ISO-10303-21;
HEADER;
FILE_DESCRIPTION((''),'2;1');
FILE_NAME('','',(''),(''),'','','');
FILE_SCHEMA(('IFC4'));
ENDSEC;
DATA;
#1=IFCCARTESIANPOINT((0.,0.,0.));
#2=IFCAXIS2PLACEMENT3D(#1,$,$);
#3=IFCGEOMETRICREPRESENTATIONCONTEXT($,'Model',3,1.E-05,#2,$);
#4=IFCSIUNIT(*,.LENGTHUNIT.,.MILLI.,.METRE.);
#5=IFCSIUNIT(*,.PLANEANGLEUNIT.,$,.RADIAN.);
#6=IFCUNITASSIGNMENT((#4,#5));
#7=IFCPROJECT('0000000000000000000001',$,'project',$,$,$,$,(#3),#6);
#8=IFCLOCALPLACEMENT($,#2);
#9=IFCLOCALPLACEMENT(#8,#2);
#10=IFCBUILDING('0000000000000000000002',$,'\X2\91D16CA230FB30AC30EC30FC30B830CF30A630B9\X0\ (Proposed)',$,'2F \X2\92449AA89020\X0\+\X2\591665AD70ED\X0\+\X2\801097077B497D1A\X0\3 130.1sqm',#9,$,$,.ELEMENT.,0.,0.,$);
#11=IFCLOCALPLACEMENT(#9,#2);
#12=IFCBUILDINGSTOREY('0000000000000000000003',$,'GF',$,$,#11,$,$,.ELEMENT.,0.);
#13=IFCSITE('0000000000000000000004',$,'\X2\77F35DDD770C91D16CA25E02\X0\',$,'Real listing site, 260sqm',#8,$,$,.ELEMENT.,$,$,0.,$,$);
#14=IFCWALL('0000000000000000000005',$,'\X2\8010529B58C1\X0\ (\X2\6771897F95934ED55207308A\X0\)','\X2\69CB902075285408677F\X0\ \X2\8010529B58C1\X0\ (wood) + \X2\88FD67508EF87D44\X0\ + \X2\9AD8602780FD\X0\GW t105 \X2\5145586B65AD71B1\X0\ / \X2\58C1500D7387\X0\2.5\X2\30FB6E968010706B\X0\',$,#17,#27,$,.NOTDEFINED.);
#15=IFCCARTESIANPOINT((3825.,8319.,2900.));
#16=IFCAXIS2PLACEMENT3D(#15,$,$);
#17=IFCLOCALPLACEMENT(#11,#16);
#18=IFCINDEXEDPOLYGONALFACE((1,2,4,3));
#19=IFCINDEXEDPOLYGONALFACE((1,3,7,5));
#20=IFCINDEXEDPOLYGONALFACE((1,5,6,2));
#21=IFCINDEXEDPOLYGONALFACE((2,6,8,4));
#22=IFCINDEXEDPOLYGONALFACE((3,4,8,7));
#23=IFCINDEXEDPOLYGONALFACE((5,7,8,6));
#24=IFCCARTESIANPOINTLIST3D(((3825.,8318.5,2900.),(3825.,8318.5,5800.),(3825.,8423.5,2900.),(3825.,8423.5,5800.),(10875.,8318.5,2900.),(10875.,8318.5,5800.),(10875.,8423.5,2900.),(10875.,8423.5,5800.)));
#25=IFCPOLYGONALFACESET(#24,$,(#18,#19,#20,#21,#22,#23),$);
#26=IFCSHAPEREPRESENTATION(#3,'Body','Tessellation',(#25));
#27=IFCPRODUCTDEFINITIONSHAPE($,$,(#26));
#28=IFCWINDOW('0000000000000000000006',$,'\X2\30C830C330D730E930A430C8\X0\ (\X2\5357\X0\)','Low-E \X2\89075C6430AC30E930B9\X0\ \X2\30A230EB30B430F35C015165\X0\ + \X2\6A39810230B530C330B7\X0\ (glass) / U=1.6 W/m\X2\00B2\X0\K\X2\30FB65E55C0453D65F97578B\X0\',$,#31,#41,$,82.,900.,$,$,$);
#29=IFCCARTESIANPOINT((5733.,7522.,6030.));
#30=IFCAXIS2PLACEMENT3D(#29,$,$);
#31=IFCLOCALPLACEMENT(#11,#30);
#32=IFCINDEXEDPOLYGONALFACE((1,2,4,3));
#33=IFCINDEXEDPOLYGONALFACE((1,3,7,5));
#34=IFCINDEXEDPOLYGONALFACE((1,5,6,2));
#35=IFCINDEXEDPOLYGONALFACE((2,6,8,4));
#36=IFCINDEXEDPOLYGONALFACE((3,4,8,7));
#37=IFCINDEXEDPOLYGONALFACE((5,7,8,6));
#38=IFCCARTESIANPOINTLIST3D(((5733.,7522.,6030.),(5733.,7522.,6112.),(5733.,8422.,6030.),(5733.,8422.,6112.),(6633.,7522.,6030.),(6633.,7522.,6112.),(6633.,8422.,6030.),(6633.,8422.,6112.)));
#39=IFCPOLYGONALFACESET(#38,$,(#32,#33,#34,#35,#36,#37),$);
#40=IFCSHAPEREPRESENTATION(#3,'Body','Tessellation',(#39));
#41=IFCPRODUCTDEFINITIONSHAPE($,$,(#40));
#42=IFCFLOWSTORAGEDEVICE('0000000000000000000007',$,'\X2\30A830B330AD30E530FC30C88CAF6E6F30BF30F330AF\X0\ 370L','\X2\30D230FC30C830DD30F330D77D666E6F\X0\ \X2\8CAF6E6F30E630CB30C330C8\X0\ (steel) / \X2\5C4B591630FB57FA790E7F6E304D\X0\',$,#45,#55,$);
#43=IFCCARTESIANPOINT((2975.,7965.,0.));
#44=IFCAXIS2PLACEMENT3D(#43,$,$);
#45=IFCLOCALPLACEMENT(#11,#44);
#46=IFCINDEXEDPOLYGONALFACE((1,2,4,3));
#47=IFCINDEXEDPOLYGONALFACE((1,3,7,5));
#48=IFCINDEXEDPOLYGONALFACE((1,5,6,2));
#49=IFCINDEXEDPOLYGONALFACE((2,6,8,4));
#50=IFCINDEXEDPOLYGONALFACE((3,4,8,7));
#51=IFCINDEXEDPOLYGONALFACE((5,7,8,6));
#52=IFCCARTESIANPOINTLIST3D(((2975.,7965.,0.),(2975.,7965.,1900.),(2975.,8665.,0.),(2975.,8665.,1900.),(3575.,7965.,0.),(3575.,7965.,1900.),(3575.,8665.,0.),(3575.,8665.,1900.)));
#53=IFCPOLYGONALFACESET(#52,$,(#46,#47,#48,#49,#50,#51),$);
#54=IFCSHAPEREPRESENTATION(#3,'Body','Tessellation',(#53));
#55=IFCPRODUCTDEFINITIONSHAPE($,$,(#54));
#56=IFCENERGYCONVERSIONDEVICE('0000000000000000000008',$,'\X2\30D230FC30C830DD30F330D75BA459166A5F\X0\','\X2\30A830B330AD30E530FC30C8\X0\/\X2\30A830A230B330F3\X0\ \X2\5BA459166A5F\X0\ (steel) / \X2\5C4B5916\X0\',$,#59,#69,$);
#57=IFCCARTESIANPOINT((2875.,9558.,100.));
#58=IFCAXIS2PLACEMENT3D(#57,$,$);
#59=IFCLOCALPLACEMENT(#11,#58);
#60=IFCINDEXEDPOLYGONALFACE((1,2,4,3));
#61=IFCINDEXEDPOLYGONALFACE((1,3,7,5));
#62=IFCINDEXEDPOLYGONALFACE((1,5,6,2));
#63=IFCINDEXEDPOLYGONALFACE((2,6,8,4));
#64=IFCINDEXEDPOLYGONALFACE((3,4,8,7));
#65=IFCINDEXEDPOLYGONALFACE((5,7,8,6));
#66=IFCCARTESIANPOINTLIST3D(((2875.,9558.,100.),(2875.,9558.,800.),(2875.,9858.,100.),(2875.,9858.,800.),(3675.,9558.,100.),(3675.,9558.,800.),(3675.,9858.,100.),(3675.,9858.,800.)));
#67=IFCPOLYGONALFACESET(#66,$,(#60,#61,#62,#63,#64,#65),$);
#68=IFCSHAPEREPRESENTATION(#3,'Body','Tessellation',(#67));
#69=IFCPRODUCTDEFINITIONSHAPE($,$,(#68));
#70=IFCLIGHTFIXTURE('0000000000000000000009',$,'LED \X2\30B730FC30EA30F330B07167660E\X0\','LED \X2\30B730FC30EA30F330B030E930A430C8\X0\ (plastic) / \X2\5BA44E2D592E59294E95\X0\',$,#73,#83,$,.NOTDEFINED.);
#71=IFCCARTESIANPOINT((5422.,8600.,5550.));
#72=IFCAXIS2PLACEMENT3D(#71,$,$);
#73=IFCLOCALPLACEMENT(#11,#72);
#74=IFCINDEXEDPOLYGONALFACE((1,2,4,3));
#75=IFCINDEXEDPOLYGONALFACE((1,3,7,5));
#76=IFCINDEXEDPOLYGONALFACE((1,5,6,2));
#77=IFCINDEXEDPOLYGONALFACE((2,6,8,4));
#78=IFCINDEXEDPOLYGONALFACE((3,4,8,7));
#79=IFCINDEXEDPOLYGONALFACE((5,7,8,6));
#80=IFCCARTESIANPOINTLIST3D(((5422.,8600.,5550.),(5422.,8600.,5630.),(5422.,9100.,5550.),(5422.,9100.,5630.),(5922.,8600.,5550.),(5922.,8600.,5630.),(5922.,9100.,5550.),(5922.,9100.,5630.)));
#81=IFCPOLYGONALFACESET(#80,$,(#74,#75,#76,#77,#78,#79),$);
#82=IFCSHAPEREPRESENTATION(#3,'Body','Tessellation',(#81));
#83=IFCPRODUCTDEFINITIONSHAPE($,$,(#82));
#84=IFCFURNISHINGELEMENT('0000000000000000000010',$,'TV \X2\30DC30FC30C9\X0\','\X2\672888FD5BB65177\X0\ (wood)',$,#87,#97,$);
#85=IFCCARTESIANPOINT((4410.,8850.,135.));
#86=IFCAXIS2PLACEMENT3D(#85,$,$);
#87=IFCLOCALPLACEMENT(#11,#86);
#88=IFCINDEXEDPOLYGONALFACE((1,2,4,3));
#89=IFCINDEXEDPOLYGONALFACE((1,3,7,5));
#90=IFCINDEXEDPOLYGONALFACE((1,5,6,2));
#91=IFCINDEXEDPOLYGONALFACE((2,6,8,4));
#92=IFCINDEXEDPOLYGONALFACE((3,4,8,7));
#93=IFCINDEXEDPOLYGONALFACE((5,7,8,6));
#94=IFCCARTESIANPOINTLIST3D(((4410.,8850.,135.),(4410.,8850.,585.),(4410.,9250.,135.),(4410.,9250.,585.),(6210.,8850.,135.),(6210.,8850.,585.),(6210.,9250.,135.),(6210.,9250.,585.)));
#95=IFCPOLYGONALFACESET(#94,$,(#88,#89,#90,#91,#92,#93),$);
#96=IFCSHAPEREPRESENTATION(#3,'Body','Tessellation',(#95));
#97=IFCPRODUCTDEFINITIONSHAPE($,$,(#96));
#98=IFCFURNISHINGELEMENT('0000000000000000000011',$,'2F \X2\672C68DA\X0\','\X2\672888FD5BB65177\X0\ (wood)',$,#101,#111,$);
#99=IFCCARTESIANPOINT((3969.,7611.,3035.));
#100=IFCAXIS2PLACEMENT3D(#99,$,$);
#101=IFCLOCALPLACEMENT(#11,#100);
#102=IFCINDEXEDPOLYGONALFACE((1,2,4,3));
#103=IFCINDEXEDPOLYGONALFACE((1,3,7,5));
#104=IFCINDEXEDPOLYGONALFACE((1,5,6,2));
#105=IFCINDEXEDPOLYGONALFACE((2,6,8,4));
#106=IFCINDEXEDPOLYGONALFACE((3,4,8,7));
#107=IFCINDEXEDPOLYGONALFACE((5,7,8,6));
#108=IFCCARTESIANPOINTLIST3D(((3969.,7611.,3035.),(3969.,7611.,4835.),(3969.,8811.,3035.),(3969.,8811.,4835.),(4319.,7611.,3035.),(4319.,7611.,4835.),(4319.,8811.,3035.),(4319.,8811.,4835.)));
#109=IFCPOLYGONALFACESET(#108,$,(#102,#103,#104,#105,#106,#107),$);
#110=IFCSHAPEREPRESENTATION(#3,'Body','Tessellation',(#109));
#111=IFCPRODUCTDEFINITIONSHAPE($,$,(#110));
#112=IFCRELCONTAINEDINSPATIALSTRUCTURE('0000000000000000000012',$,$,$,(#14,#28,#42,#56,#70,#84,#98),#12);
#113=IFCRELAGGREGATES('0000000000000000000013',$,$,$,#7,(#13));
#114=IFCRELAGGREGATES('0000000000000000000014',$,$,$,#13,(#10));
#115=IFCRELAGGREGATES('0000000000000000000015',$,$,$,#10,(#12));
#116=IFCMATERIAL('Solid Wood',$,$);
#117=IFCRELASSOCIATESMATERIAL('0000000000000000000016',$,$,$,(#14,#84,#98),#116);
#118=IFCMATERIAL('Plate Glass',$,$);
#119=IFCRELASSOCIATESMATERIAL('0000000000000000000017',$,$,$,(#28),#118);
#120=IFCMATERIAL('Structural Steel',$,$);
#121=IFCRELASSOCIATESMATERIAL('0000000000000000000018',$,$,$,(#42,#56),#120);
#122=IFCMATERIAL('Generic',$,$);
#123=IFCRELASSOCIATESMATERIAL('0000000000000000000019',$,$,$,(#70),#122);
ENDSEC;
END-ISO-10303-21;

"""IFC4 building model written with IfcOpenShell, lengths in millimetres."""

from ifc_helpers import new_model, si_unit, frame, frame_2d, origin, place, context, project, spatial, rectangle, extrude, material, element, save


model = new_model("IFC4")

# Units and contexts
model_context = context("Model", 3, precision=1e-05, world=origin())
ifc_project = project(units=[si_unit("LENGTHUNIT", "METRE", prefix="MILLI"), si_unit("PLANEANGLEUNIT", "RADIAN")], contexts=[model_context])

# Site, building, storey
site_placement = place(None, origin())
site = spatial("IfcSite", under=ifc_project, at=site_placement, Name="石川県金沢市", ObjectType="Real listing site, 260sqm", CompositionType="ELEMENT", RefElevation=0.0)
building_placement = place(site_placement, origin())
building = spatial("IfcBuilding", under=site, at=building_placement, Name="金沢・ガレージハウス (Proposed)", ObjectType="2F 鉄骨造+外断热+耐震等級3 130.1sqm", CompositionType="ELEMENT", ElevationOfRefHeight=0.0, ElevationOfTerrain=0.0)
storey_placement = place(building_placement, origin())
storey = spatial("IfcBuildingStorey", under=building, at=storey_placement, Name="GF", CompositionType="ELEMENT", Elevation=0.0)

# Shared definitions
ifc_material_1 = material(Name="Solid Wood")

# Wall
wall_1_placement = place(storey_placement, frame((3825.0, 8319.0, 2900.0)))
element("IfcWall", 1, at=wall_1_placement, inside=storey, material=ifc_material_1, Name="耐力壁 (東西間仕切り)", Description="構造用合板 耐力壁 (wood) + 製材軸組 + 高性能GW t105 充填断熱 / 壁倍率2.5・準耐火", PredefinedType="NOTDEFINED", context=model_context, shape_type="SweptSolid", body=[
    extrude(rectangle(XDim=7050.0, YDim=105.0, at=frame_2d((3525.0, 52.0))), frame((3825.0, 8319.0, 2900.0)), (0.0, 0.0, 1.0), 2900.0),
])

# Window
ifc_material_2 = material(Name="Plate Glass")
window_placement = place(storey_placement, frame((5733.0, 7522.0, 6030.0)))
element("IfcWindow", 2, at=window_placement, inside=storey, material=ifc_material_2, Name="トップライト (南)", Description="Low-E 複層ガラス アルゴン封入 + 樹脂サッシ (glass) / U=1.6 W/m²K・日射取得型", OverallHeight=82.0, OverallWidth=900.0, context=model_context, shape_type="SweptSolid", body=[
    extrude(rectangle(XDim=900.0, YDim=900.0, at=frame_2d((450.0, 450.0))), frame((5733.0, 7522.0, 6030.0)), (0.0, 0.0, 1.0), 82.0),
])

# Flow storage device
ifc_material_3 = material(Name="Structural Steel")
flow_storage_device_placement = place(storey_placement, frame((2975.0, 7965.0, 0.0)))
element("IfcFlowStorageDevice", 3, at=flow_storage_device_placement, inside=storey, material=ifc_material_3, Name="エコキュート貯湯タンク 370L", Description="ヒートポンプ給湯 貯湯ユニット (steel) / 屋外・基礎置き", context=model_context, shape_type="SweptSolid", body=[
    extrude(rectangle(XDim=600.0, YDim=700.0, at=frame_2d((300.0, 350.0))), frame((2975.0, 7965.0, 0.0)), (0.0, 0.0, 1.0), 1900.0),
])

# Energy conversion device
energy_conversion_device_placement = place(storey_placement, frame((2875.0, 9558.0, 100.0)))
element("IfcEnergyConversionDevice", 4, at=energy_conversion_device_placement, inside=storey, material=ifc_material_3, Name="ヒートポンプ室外機", Description="エコキュート/エアコン 室外機 (steel) / 屋外", context=model_context, shape_type="SweptSolid", body=[
    extrude(rectangle(XDim=800.0, YDim=300.0, at=frame_2d((400.0, 150.0))), frame((2875.0, 9558.0, 100.0)), (0.0, 0.0, 1.0), 700.0),
])

# Light fixture
ifc_material_4 = material(Name="Generic")
light_fixture_placement = place(storey_placement, frame((5422.0, 8600.0, 5550.0)))
element("IfcLightFixture", 5, at=light_fixture_placement, inside=storey, material=ifc_material_4, Name="LED シーリング照明", Description="LED シーリングライト (plastic) / 室中央天井", PredefinedType="NOTDEFINED", context=model_context, shape_type="SweptSolid", body=[
    extrude(rectangle(XDim=500.0, YDim=500.0, at=frame_2d((250.0, 250.0))), frame((5422.0, 8600.0, 5550.0)), (0.0, 0.0, 1.0), 80.0),
])

# Furnishing elements
furnishing_1_placement = place(storey_placement, frame((4410.0, 8850.0, 135.0)))
element("IfcFurnishingElement", 6, at=furnishing_1_placement, inside=storey, material=ifc_material_1, Name="TV ボード", Description="木製家具 (wood)", context=model_context, shape_type="SweptSolid", body=[
    extrude(rectangle(XDim=1800.0, YDim=400.0, at=frame_2d((900.0, 200.0))), frame((4410.0, 8850.0, 135.0)), (0.0, 0.0, 1.0), 450.0),
])
furnishing_2_placement = place(storey_placement, frame((3969.0, 7611.0, 3035.0)))
element("IfcFurnishingElement", 7, at=furnishing_2_placement, inside=storey, material=ifc_material_1, Name="2F 本棚", Description="木製家具 (wood)", context=model_context, shape_type="SweptSolid", body=[
    extrude(rectangle(XDim=350.0, YDim=1200.0, at=frame_2d((175.0, 600.0))), frame((3969.0, 7611.0, 3035.0)), (0.0, 0.0, 1.0), 1800.0),
])

save(model, "model.ifc")
